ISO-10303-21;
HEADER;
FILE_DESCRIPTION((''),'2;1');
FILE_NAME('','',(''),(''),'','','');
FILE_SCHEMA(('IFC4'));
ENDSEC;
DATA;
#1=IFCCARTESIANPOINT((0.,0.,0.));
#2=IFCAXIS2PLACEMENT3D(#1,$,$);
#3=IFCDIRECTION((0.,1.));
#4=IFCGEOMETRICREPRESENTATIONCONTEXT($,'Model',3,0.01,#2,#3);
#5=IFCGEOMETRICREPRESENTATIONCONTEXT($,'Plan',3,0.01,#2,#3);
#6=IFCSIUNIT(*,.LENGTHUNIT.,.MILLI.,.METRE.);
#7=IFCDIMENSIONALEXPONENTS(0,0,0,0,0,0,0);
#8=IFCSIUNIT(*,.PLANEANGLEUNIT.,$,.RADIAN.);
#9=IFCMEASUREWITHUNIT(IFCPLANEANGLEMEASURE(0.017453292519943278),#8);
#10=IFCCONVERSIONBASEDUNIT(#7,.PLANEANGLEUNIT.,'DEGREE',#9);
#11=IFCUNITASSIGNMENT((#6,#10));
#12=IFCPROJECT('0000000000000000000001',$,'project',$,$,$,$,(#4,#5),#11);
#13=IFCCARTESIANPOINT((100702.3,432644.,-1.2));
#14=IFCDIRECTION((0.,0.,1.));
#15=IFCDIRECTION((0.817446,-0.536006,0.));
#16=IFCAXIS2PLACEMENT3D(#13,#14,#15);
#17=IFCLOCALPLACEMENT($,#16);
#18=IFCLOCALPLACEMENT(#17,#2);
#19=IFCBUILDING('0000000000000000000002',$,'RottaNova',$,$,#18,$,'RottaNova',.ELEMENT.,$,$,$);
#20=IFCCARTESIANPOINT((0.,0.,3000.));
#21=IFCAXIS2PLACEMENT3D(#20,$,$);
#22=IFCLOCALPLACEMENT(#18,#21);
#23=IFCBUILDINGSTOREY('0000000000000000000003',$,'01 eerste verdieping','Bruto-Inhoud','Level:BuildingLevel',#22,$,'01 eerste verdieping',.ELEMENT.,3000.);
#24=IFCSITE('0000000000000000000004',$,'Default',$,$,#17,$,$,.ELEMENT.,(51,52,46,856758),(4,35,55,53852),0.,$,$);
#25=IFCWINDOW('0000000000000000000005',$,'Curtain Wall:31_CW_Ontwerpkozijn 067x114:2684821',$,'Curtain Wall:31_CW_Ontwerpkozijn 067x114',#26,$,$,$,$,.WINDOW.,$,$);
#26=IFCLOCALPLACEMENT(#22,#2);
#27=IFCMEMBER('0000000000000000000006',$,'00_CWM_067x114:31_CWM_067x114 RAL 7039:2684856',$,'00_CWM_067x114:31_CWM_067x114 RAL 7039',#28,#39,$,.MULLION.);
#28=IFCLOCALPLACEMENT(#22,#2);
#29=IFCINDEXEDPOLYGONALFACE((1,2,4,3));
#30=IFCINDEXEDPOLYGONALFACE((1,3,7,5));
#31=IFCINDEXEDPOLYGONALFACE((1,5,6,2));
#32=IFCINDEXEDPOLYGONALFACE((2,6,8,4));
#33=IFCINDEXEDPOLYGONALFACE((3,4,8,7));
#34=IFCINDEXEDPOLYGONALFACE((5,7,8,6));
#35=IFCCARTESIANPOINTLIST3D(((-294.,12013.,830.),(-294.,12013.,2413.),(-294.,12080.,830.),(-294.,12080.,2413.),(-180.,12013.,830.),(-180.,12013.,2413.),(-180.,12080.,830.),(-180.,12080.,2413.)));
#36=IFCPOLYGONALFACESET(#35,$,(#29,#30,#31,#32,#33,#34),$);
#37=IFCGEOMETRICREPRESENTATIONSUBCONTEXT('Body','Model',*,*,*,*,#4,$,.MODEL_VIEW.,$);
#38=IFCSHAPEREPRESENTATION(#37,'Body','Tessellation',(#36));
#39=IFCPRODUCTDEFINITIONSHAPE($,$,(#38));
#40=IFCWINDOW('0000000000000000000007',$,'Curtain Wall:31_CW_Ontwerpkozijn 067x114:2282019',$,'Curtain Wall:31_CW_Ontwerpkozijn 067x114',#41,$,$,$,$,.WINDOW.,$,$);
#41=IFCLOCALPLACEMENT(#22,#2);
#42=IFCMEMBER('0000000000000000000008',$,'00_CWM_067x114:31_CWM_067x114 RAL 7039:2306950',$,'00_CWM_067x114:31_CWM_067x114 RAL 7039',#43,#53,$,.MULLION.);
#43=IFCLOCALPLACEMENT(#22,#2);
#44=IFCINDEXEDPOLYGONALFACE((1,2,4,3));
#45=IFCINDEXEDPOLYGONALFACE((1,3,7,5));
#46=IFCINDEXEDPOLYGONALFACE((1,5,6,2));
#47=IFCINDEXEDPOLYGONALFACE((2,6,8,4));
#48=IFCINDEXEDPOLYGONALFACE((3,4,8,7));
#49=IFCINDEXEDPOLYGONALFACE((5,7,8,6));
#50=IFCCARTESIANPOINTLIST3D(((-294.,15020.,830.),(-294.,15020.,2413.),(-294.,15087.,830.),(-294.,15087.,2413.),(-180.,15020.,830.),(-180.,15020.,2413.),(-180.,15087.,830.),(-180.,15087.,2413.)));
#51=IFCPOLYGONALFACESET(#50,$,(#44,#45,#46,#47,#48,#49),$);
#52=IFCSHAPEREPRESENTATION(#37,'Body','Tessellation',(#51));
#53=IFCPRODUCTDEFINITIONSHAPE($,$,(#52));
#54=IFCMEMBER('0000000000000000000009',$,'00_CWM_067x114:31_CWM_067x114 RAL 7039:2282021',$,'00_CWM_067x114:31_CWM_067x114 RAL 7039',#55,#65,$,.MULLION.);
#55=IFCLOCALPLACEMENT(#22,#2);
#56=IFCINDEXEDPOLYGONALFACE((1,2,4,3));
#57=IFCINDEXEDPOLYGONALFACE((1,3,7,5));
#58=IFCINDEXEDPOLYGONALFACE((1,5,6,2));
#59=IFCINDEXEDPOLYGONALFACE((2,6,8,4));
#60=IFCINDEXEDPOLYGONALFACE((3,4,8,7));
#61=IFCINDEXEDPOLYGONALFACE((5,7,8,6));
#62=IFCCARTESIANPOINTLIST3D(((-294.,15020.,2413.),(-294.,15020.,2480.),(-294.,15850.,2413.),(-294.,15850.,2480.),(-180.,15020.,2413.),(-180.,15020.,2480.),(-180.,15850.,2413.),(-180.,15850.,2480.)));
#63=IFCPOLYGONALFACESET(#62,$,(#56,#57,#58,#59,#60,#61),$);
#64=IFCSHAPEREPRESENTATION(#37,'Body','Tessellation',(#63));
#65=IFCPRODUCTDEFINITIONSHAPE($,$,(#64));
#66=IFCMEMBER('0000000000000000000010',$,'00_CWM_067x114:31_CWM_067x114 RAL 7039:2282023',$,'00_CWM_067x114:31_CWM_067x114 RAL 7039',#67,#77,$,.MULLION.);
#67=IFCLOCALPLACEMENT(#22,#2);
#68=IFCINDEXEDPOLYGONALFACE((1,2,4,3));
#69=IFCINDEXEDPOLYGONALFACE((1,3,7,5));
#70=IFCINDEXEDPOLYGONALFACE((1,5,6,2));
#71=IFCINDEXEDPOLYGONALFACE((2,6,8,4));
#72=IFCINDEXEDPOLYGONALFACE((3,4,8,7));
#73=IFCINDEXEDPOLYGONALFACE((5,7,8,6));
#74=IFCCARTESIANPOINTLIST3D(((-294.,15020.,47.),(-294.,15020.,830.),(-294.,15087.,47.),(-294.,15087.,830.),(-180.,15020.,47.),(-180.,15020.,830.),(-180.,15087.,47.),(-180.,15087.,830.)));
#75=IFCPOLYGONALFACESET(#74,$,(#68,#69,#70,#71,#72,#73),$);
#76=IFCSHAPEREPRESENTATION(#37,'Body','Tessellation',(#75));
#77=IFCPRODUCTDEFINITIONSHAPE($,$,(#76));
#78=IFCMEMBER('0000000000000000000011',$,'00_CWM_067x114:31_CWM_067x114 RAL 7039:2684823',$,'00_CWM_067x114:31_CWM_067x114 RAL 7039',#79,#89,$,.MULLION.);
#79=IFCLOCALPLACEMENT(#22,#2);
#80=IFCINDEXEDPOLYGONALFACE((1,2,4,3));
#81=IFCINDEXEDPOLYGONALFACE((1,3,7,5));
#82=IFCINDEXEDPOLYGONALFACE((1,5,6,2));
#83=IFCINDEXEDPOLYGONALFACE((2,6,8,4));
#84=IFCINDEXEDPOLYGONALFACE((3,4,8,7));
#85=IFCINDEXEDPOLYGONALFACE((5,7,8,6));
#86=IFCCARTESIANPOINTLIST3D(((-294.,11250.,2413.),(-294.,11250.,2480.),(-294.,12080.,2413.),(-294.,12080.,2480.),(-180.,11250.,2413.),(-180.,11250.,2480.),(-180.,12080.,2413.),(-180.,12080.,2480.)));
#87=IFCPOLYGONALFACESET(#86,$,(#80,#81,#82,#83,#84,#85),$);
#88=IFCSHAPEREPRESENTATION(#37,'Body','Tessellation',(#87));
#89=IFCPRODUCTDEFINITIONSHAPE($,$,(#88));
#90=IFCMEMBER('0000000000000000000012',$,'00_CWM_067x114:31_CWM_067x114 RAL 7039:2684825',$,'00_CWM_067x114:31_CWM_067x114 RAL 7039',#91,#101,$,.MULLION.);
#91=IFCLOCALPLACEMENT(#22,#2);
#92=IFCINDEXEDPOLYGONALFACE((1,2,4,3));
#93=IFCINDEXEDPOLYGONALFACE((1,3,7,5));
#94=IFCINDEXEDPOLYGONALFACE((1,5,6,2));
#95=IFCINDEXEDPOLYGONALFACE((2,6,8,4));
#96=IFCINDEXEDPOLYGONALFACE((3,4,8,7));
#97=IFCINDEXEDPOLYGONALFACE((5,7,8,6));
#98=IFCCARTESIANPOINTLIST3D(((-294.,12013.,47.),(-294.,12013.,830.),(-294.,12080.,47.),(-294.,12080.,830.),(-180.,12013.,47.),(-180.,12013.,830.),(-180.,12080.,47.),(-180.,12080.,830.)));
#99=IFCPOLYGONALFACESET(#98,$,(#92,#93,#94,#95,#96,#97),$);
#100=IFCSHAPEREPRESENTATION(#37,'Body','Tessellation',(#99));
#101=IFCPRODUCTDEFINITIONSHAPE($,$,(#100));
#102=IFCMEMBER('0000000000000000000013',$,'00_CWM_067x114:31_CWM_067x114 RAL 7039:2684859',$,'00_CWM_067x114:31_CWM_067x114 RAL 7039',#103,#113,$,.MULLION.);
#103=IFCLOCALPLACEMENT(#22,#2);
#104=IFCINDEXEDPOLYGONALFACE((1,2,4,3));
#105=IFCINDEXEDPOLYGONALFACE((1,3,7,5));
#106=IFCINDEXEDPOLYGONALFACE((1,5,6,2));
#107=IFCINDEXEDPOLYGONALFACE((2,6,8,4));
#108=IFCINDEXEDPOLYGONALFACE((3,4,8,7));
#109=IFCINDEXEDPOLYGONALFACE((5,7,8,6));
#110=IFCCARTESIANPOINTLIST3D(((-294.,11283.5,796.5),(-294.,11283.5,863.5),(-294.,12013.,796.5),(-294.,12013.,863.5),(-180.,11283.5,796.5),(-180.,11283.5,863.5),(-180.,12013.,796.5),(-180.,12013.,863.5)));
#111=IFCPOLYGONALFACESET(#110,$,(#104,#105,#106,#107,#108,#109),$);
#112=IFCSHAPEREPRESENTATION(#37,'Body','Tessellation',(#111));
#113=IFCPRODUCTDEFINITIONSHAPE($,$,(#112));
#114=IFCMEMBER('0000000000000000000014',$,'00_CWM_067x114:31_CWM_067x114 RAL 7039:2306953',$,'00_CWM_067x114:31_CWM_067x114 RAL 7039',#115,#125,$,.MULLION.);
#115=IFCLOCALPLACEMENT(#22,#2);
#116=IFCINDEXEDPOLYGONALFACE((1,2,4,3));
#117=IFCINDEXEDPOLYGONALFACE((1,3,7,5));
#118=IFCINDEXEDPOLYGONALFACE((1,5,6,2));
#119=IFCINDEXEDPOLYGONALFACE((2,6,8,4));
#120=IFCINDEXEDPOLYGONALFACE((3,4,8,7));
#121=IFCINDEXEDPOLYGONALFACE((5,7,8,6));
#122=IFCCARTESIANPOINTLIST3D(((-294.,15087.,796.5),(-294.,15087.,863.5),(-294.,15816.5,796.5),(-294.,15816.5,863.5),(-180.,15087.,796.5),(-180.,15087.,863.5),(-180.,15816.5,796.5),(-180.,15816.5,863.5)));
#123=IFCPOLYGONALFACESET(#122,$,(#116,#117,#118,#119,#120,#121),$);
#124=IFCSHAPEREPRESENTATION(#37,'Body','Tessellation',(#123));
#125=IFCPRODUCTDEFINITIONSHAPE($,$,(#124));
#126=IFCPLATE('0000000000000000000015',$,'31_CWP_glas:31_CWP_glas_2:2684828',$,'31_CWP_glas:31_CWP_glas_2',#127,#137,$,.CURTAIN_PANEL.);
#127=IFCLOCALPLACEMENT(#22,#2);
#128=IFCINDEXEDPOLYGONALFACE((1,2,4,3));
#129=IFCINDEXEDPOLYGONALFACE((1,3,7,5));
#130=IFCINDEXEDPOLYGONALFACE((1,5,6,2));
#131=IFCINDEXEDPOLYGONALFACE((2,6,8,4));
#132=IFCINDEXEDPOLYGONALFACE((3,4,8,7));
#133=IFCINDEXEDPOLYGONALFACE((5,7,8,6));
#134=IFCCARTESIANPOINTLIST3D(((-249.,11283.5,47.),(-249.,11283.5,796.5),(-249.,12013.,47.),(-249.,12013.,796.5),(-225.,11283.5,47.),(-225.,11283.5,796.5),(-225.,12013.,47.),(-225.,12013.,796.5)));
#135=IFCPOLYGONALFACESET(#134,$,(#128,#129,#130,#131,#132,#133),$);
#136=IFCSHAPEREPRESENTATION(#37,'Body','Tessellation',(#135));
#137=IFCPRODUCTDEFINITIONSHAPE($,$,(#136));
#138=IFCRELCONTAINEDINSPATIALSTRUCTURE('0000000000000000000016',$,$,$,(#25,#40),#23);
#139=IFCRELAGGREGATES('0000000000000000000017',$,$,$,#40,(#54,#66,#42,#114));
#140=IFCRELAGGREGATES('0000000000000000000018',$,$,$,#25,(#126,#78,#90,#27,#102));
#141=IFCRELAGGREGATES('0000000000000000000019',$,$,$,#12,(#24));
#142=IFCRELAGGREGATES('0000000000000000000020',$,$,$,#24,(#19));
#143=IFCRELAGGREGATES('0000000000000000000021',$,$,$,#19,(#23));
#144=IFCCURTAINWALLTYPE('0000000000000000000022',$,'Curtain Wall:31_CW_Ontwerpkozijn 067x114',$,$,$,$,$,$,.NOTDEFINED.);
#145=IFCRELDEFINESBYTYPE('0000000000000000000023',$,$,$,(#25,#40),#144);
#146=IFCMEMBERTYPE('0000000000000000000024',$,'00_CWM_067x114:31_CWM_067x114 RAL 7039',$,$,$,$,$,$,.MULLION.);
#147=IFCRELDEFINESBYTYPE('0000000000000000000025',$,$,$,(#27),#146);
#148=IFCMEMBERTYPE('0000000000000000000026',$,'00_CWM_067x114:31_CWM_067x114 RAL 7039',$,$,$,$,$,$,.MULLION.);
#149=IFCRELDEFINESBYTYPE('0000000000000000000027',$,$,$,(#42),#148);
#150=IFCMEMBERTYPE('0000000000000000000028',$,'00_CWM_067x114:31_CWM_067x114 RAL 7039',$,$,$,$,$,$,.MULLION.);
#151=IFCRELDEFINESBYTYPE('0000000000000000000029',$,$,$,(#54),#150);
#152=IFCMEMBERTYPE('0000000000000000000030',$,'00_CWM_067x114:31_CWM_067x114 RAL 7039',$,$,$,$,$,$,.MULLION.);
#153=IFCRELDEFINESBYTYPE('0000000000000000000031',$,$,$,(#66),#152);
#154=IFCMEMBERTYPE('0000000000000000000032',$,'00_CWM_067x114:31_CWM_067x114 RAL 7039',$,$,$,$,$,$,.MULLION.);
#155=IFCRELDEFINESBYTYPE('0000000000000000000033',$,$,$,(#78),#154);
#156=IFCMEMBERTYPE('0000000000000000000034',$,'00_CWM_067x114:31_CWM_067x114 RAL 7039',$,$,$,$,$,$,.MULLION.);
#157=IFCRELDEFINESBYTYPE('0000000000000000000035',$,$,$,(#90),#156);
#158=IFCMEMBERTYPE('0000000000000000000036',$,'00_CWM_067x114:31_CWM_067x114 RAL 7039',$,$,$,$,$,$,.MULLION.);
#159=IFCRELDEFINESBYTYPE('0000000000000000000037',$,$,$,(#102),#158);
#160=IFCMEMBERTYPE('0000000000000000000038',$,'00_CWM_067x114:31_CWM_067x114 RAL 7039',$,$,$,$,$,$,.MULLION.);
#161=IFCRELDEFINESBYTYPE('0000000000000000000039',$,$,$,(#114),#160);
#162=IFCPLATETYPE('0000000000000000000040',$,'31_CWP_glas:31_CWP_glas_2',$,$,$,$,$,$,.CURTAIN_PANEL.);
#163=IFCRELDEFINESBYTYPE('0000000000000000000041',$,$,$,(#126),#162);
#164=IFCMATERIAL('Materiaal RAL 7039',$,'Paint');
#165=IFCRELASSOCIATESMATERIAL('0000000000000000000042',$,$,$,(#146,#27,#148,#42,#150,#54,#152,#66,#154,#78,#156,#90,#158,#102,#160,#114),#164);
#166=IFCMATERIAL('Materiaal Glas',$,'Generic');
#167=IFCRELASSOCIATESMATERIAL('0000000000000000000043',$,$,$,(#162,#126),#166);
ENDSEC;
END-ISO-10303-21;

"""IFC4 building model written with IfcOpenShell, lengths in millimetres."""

from ifc_helpers import new_model, entity, si_unit, converted_unit, direction, frame, origin, place, context, subcontext, project, spatial, indexed_curve, outline, extrude, source, transform, mapped, material, type_object, type_shapes, element, aggregate, save


model = new_model("IFC4")

# Units and contexts
model_context = context("Model", 3, precision=0.01, world=origin(), true_north=direction((0.0, 1.0)))
plan_context = context("Plan", 3, precision=0.01, world=origin(), true_north=direction((0.0, 1.0)))
body_context = subcontext(model_context, "Body", "Model", "MODEL_VIEW")
ifc_project = project(units=[si_unit("LENGTHUNIT", "METRE", prefix="MILLI"), converted_unit("PLANEANGLEUNIT", "DEGREE", entity("IfcPlaneAngleMeasure", 0.017453292519943278), si_unit("PLANEANGLEUNIT", "RADIAN"), dimensions=[0, 0, 0, 0, 0, 0, 0])], contexts=[model_context, plan_context])

# Site, building, storey
site_placement = place(None, frame((100702.3, 432644.0, -1.2), z_axis=(0.0, 0.0, 1.0), x_axis=(0.817446, -0.536006, 0.0)))
site = spatial("IfcSite", under=ifc_project, at=site_placement, Name="Default", CompositionType="ELEMENT", RefLatitude=(51, 52, 46, 856758), RefLongitude=(4, 35, 55, 53852), RefElevation=0.0)
building_placement = place(site_placement, origin())
building = spatial("IfcBuilding", under=site, at=building_placement, Name="RottaNova", LongName="RottaNova", CompositionType="ELEMENT")
storey_placement = place(building_placement, frame((0.0, 0.0, 3000.0)))
storey = spatial("IfcBuildingStorey", under=building, at=storey_placement, Name="01 eerste verdieping", Description="Bruto-Inhoud", ObjectType="Level:BuildingLevel", LongName="01 eerste verdieping", CompositionType="ELEMENT", Elevation=3000.0)

# Window, member
curtain_wall_type = type_object("IfcCurtainWallType", Name="Curtain Wall:31_CW_Ontwerpkozijn 067x114", PredefinedType="NOTDEFINED")
window_1_placement = place(storey_placement, frame((0.0, 0.0, -3000.0)))
window_1 = element("IfcWindow", 1, at=window_1_placement, inside=storey, type_object=curtain_wall_type, Name="Curtain Wall:31_CW_Ontwerpkozijn 067x114:2684821", ObjectType="Curtain Wall:31_CW_Ontwerpkozijn 067x114", PredefinedType="WINDOW")
ifc_material_1 = material(Name="Materiaal RAL 7039", Category="Paint")
member_type_1 = type_object("IfcMemberType", Name="00_CWM_067x114:31_CWM_067x114 RAL 7039", PredefinedType="MULLION", material=ifc_material_1)
shared_shape_1 = source(origin(), body_context, "Body", "SweptSolid", [
    extrude(outline(indexed_curve([(-33.5, -57.0), (33.5, -57.0), (33.5, 57.0), (-33.5, 57.0), (-33.5, -57.0)], self_intersect=False)), frame((-33.5, -57.0, -1583.0), z_axis=(0.0, 0.0, 1.0), x_axis=(-1.0, 0.0, 0.0)), (0.0, 0.0, 1.0), 1583.0),
])
type_shapes(member_type_1, [shared_shape_1])
member_1_placement = place(window_1_placement, frame((-180.0, 12080.0, 3830.0), z_axis=(0.0, 0.0, -1.0), x_axis=(0.0, 1.0, 0.0)))
member_1 = element("IfcMember", 2, at=member_1_placement, type_object=member_type_1, material=ifc_material_1, Name="00_CWM_067x114:31_CWM_067x114 RAL 7039:2684856", ObjectType="00_CWM_067x114:31_CWM_067x114 RAL 7039", PredefinedType="MULLION", context=body_context, shape_type="MappedRepresentation", body=[
    mapped(shared_shape_1, transform((0.0, 0.0, 0.0), scale=1.0)),
])

# Window, members
window_2_placement = place(storey_placement, frame((0.0, 0.0, -3000.0)))
window_2 = element("IfcWindow", 3, at=window_2_placement, inside=storey, type_object=curtain_wall_type, Name="Curtain Wall:31_CW_Ontwerpkozijn 067x114:2282019", ObjectType="Curtain Wall:31_CW_Ontwerpkozijn 067x114", PredefinedType="WINDOW")
member_type_2 = type_object("IfcMemberType", Name="00_CWM_067x114:31_CWM_067x114 RAL 7039", PredefinedType="MULLION", material=ifc_material_1)
shared_shape_2 = source(origin(), body_context, "Body", "SweptSolid", [
    extrude(outline(indexed_curve([(-33.5, -57.0), (33.5, -57.0), (33.5, 57.0), (-33.5, 57.0), (-33.5, -57.0)], self_intersect=False)), frame((-33.5, 57.0, -1583.0), z_axis=(0.0, 0.0, 1.0), x_axis=(-1.0, 0.0, 0.0)), (0.0, 0.0, 1.0), 1583.0),
])
type_shapes(member_type_2, [shared_shape_2])
member_2_placement = place(window_2_placement, frame((-180.0, 15020.0, 3830.0), z_axis=(0.0, 0.0, -1.0), x_axis=(0.0, -1.0, 0.0)))
member_2 = element("IfcMember", 4, at=member_2_placement, type_object=member_type_2, material=ifc_material_1, Name="00_CWM_067x114:31_CWM_067x114 RAL 7039:2306950", ObjectType="00_CWM_067x114:31_CWM_067x114 RAL 7039", PredefinedType="MULLION", context=body_context, shape_type="MappedRepresentation", body=[
    mapped(shared_shape_2, transform((0.0, 0.0, 0.0), scale=1.0)),
])
member_type_3 = type_object("IfcMemberType", Name="00_CWM_067x114:31_CWM_067x114 RAL 7039", PredefinedType="MULLION", material=ifc_material_1)
shared_shape_3 = source(origin(), body_context, "Body", "SweptSolid", [
    extrude(outline(indexed_curve([(-33.5, -57.0), (33.5, -57.0), (33.5, 57.0), (-33.5, 57.0), (-33.5, -57.0)], self_intersect=False)), frame((-33.5, 57.0, -830.0), z_axis=(0.0, 0.0, 1.0), x_axis=(-1.0, 0.0, 0.0)), (0.0, 0.0, 1.0), 830.0),
])
type_shapes(member_type_3, [shared_shape_3])
member_3_placement = place(window_2_placement, frame((-180.0, 15020.0, 5480.0), z_axis=(0.0, -1.0, 0.0), x_axis=(0.0, 0.0, 1.0)))
member_3 = element("IfcMember", 5, at=member_3_placement, type_object=member_type_3, material=ifc_material_1, Name="00_CWM_067x114:31_CWM_067x114 RAL 7039:2282021", ObjectType="00_CWM_067x114:31_CWM_067x114 RAL 7039", PredefinedType="MULLION", context=body_context, shape_type="MappedRepresentation", body=[
    mapped(shared_shape_3, transform((0.0, 0.0, 0.0), scale=1.0)),
])
member_type_4 = type_object("IfcMemberType", Name="00_CWM_067x114:31_CWM_067x114 RAL 7039", PredefinedType="MULLION", material=ifc_material_1)
shared_shape_4 = source(origin(), body_context, "Body", "SweptSolid", [
    extrude(outline(indexed_curve([(-33.5, -57.0), (33.5, -57.0), (33.5, 57.0), (-33.5, 57.0), (-33.5, -57.0)], self_intersect=False)), frame((-33.5, 57.0, -783.0), z_axis=(0.0, 0.0, 1.0), x_axis=(-1.0, 0.0, 0.0)), (0.0, 0.0, 1.0), 783.0),
])
type_shapes(member_type_4, [shared_shape_4])
member_4_placement = place(window_2_placement, frame((-180.0, 15020.0, 3047.0), z_axis=(0.0, 0.0, -1.0), x_axis=(0.0, -1.0, 0.0)))
member_4 = element("IfcMember", 6, at=member_4_placement, type_object=member_type_4, material=ifc_material_1, Name="00_CWM_067x114:31_CWM_067x114 RAL 7039:2282023", ObjectType="00_CWM_067x114:31_CWM_067x114 RAL 7039", PredefinedType="MULLION", context=body_context, shape_type="MappedRepresentation", body=[
    mapped(shared_shape_4, transform((0.0, 0.0, 0.0), scale=1.0)),
])

# Members
member_type_5 = type_object("IfcMemberType", Name="00_CWM_067x114:31_CWM_067x114 RAL 7039", PredefinedType="MULLION", material=ifc_material_1)
shared_shape_5 = source(origin(), body_context, "Body", "SweptSolid", [
    extrude(outline(indexed_curve([(-33.5, -57.0), (33.5, -57.0), (33.5, 57.0), (-33.5, 57.0), (-33.5, -57.0)], self_intersect=False)), frame((-33.5, -57.0, -830.0), z_axis=(0.0, 0.0, 1.0), x_axis=(-1.0, 0.0, 0.0)), (0.0, 0.0, 1.0), 830.0),
])
type_shapes(member_type_5, [shared_shape_5])
member_5_placement = place(window_1_placement, frame((-180.0, 12080.0, 5480.0), z_axis=(0.0, 1.0, 0.0), x_axis=(0.0, 0.0, 1.0)))
member_5 = element("IfcMember", 7, at=member_5_placement, type_object=member_type_5, material=ifc_material_1, Name="00_CWM_067x114:31_CWM_067x114 RAL 7039:2684823", ObjectType="00_CWM_067x114:31_CWM_067x114 RAL 7039", PredefinedType="MULLION", context=body_context, shape_type="MappedRepresentation", body=[
    mapped(shared_shape_5, transform((0.0, 0.0, 0.0), scale=1.0)),
])
member_type_6 = type_object("IfcMemberType", Name="00_CWM_067x114:31_CWM_067x114 RAL 7039", PredefinedType="MULLION", material=ifc_material_1)
shared_shape_6 = source(origin(), body_context, "Body", "SweptSolid", [
    extrude(outline(indexed_curve([(-33.5, -57.0), (33.5, -57.0), (33.5, 57.0), (-33.5, 57.0), (-33.5, -57.0)], self_intersect=False)), frame((-33.5, -57.0, -783.0), z_axis=(0.0, 0.0, 1.0), x_axis=(-1.0, 0.0, 0.0)), (0.0, 0.0, 1.0), 783.0),
])
type_shapes(member_type_6, [shared_shape_6])
member_6_placement = place(window_1_placement, frame((-180.0, 12080.0, 3047.0), z_axis=(0.0, 0.0, -1.0), x_axis=(0.0, 1.0, 0.0)))
member_6 = element("IfcMember", 8, at=member_6_placement, type_object=member_type_6, material=ifc_material_1, Name="00_CWM_067x114:31_CWM_067x114 RAL 7039:2684825", ObjectType="00_CWM_067x114:31_CWM_067x114 RAL 7039", PredefinedType="MULLION", context=body_context, shape_type="MappedRepresentation", body=[
    mapped(shared_shape_6, transform((0.0, 0.0, 0.0), scale=1.0)),
])
member_type_7 = type_object("IfcMemberType", Name="00_CWM_067x114:31_CWM_067x114 RAL 7039", PredefinedType="MULLION", material=ifc_material_1)
shared_shape_7 = source(origin(), body_context, "Body", "SweptSolid", [
    extrude(outline(indexed_curve([(-33.5, -57.0), (33.5, -57.0), (33.5, 57.0), (-33.5, 57.0), (-33.5, -57.0)], self_intersect=False)), frame((0.0, -57.0, -729.5), z_axis=(0.0, 0.0, 1.0), x_axis=(-1.0, 0.0, 0.0)), (0.0, 0.0, 1.0), 729.5),
])
type_shapes(member_type_7, [shared_shape_7])
member_7_placement = place(window_1_placement, frame((-180.0, 12013.0, 3830.0), z_axis=(0.0, 1.0, 0.0), x_axis=(0.0, 0.0, 1.0)))
member_7 = element("IfcMember", 9, at=member_7_placement, type_object=member_type_7, material=ifc_material_1, Name="00_CWM_067x114:31_CWM_067x114 RAL 7039:2684859", ObjectType="00_CWM_067x114:31_CWM_067x114 RAL 7039", PredefinedType="MULLION", context=body_context, shape_type="MappedRepresentation", body=[
    mapped(shared_shape_7, transform((0.0, 0.0, 0.0), scale=1.0)),
])
member_type_8 = type_object("IfcMemberType", Name="00_CWM_067x114:31_CWM_067x114 RAL 7039", PredefinedType="MULLION", material=ifc_material_1)
shared_shape_8 = source(origin(), body_context, "Body", "SweptSolid", [
    extrude(outline(indexed_curve([(-33.5, -57.0), (33.5, -57.0), (33.5, 57.0), (-33.5, 57.0), (-33.5, -57.0)], self_intersect=False)), frame((0.0, 57.0, -729.5), z_axis=(0.0, 0.0, 1.0), x_axis=(-1.0, 0.0, 0.0)), (0.0, 0.0, 1.0), 729.5),
])
type_shapes(member_type_8, [shared_shape_8])
member_8_placement = place(window_2_placement, frame((-180.0, 15087.0, 3830.0), z_axis=(0.0, -1.0, 0.0), x_axis=(0.0, 0.0, 1.0)))
member_8 = element("IfcMember", 10, at=member_8_placement, type_object=member_type_8, material=ifc_material_1, Name="00_CWM_067x114:31_CWM_067x114 RAL 7039:2306953", ObjectType="00_CWM_067x114:31_CWM_067x114 RAL 7039", PredefinedType="MULLION", context=body_context, shape_type="MappedRepresentation", body=[
    mapped(shared_shape_8, transform((0.0, 0.0, 0.0), scale=1.0)),
])
aggregate(window_2, [member_3, member_4, member_2, member_8])

# Plate
ifc_material_2 = material(Name="Materiaal Glas", Category="Generic")
plate_type_1 = type_object("IfcPlateType", Name="31_CWP_glas:31_CWP_glas_2", PredefinedType="CURTAIN_PANEL", material=ifc_material_2)
shared_shape_9 = source(origin(), body_context, "Body", "SweptSolid", [
    extrude(outline(indexed_curve([(-12.0, -364.7), (12.0, -364.7), (12.0, 364.7), (-12.0, 364.7), (-12.0, -364.7)], self_intersect=False)), frame((0.0, 57.0, 0.0), z_axis=(0.0, 0.0, 1.0), x_axis=(0.0, 1.0, 0.0)), (0.0, 0.0, 1.0), 749.5),
])
type_shapes(plate_type_1, [shared_shape_9])
plate_1_placement = place(window_1_placement, frame((-180.0, 11648.2, 3047.0), z_axis=(0.0, 0.0, 1.0), x_axis=(0.0, 1.0, 0.0)))
plate_1 = element("IfcPlate", 11, at=plate_1_placement, type_object=plate_type_1, material=ifc_material_2, Name="31_CWP_glas:31_CWP_glas_2:2684828", ObjectType="31_CWP_glas:31_CWP_glas_2", PredefinedType="CURTAIN_PANEL", context=body_context, shape_type="MappedRepresentation", body=[
    mapped(shared_shape_9, transform((0.0, 0.0, 0.0), scale=1.0)),
])
aggregate(window_1, [plate_1, member_5, member_6, member_1, member_7])

save(model, "model.ifc")
